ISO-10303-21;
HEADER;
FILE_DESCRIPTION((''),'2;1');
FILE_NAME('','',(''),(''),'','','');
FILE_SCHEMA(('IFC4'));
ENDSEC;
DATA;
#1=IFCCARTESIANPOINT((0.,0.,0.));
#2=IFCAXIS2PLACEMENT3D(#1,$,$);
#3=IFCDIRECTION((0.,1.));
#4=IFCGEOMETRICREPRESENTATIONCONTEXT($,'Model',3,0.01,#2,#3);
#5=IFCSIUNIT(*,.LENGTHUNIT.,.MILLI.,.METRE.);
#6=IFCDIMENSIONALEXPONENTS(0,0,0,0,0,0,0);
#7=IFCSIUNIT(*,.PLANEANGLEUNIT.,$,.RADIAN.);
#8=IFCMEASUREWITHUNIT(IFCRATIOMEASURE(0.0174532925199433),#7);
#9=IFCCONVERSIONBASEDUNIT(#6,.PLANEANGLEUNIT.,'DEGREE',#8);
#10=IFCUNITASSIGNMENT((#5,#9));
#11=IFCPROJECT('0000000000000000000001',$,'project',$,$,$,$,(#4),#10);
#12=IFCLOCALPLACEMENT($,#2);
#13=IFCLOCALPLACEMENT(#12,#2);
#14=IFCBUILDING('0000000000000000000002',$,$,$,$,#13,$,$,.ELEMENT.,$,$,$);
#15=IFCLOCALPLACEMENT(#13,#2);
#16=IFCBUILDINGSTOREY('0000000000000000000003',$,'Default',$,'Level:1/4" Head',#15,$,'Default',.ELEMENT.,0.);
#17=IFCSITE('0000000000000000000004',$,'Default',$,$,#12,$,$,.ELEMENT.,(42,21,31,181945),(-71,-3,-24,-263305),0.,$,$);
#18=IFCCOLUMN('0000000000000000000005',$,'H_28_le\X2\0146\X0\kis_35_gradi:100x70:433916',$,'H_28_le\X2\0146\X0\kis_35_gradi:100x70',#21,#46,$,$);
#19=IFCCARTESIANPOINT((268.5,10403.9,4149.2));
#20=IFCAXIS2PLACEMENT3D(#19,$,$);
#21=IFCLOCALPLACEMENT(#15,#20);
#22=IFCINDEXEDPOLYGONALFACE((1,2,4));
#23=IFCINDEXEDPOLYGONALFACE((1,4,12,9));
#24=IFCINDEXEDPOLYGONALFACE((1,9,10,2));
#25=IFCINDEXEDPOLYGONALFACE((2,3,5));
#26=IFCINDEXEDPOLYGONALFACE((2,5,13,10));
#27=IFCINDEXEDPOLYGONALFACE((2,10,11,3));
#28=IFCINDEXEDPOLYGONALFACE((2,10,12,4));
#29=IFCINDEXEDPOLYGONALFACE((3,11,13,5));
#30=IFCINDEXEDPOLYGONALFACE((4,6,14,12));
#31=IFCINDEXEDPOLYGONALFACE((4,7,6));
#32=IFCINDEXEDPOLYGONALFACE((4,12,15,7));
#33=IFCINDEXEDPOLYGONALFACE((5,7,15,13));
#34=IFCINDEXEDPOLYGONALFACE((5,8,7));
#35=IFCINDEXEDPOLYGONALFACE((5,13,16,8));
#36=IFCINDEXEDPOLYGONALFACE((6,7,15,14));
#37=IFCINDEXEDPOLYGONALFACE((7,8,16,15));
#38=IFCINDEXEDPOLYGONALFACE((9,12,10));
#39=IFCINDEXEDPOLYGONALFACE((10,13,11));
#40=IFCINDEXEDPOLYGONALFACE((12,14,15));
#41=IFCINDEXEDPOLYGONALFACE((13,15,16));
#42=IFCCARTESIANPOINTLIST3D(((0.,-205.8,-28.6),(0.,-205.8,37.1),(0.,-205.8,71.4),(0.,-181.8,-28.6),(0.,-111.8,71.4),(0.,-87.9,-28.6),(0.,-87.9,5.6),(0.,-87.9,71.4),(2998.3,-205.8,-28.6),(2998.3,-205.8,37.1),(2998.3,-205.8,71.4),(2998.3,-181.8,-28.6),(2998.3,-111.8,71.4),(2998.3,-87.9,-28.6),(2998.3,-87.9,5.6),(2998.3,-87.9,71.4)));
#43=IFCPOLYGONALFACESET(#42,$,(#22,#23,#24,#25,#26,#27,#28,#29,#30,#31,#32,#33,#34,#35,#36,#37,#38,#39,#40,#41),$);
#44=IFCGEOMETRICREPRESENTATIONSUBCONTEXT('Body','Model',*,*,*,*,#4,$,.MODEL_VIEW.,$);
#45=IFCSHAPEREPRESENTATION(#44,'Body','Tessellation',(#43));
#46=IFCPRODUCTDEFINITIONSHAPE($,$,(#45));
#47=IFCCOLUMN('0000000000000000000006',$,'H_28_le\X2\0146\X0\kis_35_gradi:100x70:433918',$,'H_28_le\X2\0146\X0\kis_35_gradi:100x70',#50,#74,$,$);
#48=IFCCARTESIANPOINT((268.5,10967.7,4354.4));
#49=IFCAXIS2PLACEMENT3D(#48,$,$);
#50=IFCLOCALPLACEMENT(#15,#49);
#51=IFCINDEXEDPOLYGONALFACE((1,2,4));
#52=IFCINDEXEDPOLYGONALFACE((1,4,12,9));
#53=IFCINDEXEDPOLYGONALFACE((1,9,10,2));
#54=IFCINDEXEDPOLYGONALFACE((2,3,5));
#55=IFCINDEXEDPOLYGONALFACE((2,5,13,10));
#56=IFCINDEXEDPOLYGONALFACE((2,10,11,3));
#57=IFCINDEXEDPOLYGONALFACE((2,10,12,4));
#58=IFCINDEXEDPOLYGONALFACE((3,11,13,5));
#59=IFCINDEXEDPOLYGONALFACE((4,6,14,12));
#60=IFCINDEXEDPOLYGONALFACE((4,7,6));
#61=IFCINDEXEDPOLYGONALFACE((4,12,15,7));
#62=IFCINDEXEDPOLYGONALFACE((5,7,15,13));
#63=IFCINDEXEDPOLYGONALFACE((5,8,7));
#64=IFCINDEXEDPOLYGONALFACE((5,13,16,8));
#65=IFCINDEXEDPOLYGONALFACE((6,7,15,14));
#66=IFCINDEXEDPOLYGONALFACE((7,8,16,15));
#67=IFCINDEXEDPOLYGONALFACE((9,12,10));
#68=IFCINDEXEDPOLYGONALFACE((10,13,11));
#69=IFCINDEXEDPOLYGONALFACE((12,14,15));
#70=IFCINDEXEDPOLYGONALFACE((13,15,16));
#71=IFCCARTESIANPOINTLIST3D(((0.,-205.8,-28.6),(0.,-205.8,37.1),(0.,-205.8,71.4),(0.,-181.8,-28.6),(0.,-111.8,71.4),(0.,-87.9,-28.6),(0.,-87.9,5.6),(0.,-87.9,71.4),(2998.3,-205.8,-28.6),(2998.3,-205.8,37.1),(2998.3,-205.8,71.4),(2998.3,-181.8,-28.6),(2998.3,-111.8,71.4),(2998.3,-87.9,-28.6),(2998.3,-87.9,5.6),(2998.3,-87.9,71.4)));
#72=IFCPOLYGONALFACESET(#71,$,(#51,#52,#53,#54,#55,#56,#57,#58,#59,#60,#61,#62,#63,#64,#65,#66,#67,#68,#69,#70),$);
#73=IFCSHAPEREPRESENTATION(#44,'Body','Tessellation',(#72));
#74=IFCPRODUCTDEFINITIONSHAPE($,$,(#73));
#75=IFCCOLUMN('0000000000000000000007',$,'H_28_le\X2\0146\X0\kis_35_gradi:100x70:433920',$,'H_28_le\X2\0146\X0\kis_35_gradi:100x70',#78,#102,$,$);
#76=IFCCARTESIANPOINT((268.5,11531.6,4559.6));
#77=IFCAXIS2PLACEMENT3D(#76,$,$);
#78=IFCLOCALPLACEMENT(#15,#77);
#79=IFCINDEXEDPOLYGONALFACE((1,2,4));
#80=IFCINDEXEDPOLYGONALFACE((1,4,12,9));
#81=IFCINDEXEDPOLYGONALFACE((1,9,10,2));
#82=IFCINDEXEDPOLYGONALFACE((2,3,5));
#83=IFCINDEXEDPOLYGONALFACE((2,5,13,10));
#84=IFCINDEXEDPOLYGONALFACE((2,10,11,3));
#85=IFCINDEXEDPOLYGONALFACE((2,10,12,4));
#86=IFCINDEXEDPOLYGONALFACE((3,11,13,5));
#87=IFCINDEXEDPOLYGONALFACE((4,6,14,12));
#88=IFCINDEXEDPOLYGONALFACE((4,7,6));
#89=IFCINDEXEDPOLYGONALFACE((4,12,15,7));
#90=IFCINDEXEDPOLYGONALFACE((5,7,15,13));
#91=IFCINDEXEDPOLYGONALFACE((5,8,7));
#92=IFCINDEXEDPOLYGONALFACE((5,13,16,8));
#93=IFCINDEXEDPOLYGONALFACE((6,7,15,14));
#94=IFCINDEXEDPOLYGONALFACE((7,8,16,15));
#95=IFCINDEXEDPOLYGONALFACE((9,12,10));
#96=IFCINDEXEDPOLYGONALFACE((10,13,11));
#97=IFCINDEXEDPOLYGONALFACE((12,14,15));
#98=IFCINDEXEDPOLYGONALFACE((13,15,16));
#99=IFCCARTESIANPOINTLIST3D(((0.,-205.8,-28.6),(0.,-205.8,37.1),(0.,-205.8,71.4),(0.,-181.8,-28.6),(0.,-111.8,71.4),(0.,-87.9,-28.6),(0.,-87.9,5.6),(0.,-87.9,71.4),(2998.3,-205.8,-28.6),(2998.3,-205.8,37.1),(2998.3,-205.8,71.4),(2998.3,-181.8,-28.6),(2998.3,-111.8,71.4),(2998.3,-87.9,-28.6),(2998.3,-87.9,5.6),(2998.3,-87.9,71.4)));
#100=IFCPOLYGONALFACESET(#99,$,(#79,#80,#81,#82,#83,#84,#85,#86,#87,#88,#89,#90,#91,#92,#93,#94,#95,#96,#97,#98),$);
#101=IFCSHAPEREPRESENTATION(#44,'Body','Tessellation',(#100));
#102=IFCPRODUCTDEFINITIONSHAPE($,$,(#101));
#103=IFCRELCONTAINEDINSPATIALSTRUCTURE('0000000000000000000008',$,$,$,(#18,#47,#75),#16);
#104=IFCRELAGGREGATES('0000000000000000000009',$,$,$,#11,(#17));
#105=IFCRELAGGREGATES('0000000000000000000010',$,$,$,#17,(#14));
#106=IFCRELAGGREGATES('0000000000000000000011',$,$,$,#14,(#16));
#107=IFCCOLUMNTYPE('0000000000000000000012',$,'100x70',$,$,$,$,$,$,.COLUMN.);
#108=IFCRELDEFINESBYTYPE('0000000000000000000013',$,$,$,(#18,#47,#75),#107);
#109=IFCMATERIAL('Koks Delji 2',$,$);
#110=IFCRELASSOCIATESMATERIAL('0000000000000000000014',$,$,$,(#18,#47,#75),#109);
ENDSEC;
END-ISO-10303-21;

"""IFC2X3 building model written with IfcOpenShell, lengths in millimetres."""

from ifc_helpers import new_model, entity, si_unit, converted_unit, direction, frame, frame_2d, origin, place, context, subcontext, project, spatial, rectangle, extrude, boolean, source, transform, mapped, material, type_object, type_shapes, element, save


model = new_model("IFC2X3")

# Units and contexts
model_context = context("Model", 3, precision=0.01, world=origin(), true_north=direction((0.0, 1.0)))
body_context = subcontext(model_context, "Body", "Model", "MODEL_VIEW")
ifc_project = project(units=[si_unit("LENGTHUNIT", "METRE", prefix="MILLI"), converted_unit("PLANEANGLEUNIT", "DEGREE", entity("IfcRatioMeasure", 0.0174532925199433), si_unit("PLANEANGLEUNIT", "RADIAN"), dimensions=[0, 0, 0, 0, 0, 0, 0])], contexts=[model_context])

# Site, building, storey
site_placement = place(None, origin())
site = spatial("IfcSite", under=ifc_project, at=site_placement, Name="Default", CompositionType="ELEMENT", RefLatitude=(42, 21, 31, 181945), RefLongitude=(-71, -3, -24, -263305), RefElevation=0.0)
building_placement = place(site_placement, origin())
building = spatial("IfcBuilding", under=site, at=building_placement, CompositionType="ELEMENT")
storey_placement = place(building_placement, origin())
storey = spatial("IfcBuildingStorey", under=building, at=storey_placement, Name="Default", ObjectType="Level:1/4\" Head", LongName="Default", CompositionType="ELEMENT", Elevation=0.0)

# Columns
ifc_material_1 = material(Name="Koks Delji 2")
column_type = type_object("IfcColumnType", Name="100x70", PredefinedType="COLUMN")
shared_shape_1 = source(origin(), body_context, "Body", "CSG", [
    boolean("DIFFERENCE", extrude(rectangle(XDim=2998.3, YDim=117.9, at=frame_2d((0.0, 0.0), x_axis=(1.0, 0.0))), frame((1499.1, -146.8, -28.6)), (0.0, 0.0, 1.0), 100.0), extrude(rectangle(XDim=70.0, YDim=100.0, at=frame_2d((0.0, 0.0), x_axis=(0.0, 1.0))), frame((0.0, -146.8, 21.4), z_axis=(-1.0, 0.0, 0.0), x_axis=(0.0, -0.939693, -0.34202)), (0.0, 0.0, -1.0), 2998.3)),
])
type_shapes(column_type, [shared_shape_1])
for number, where, name in (
    (1, (268.5, 10403.9, 4149.2), "H_28_leņkis_35_gradi:100x70:433916"),
    (2, (268.5, 10967.7, 4354.4), "H_28_leņkis_35_gradi:100x70:433918"),
    (3, (268.5, 11531.6, 4559.6), "H_28_leņkis_35_gradi:100x70:433920"),
):
    element("IfcColumn", number, at=place(storey_placement, frame(where)), inside=storey, type_object=column_type, material=ifc_material_1, Name=name, ObjectType="H_28_leņkis_35_gradi:100x70", context=body_context, shape_type="MappedRepresentation", body=[
        mapped(shared_shape_1, transform((0.0, 0.0, 0.0), scale=1.0)),
    ])

save(model, "model.ifc")
